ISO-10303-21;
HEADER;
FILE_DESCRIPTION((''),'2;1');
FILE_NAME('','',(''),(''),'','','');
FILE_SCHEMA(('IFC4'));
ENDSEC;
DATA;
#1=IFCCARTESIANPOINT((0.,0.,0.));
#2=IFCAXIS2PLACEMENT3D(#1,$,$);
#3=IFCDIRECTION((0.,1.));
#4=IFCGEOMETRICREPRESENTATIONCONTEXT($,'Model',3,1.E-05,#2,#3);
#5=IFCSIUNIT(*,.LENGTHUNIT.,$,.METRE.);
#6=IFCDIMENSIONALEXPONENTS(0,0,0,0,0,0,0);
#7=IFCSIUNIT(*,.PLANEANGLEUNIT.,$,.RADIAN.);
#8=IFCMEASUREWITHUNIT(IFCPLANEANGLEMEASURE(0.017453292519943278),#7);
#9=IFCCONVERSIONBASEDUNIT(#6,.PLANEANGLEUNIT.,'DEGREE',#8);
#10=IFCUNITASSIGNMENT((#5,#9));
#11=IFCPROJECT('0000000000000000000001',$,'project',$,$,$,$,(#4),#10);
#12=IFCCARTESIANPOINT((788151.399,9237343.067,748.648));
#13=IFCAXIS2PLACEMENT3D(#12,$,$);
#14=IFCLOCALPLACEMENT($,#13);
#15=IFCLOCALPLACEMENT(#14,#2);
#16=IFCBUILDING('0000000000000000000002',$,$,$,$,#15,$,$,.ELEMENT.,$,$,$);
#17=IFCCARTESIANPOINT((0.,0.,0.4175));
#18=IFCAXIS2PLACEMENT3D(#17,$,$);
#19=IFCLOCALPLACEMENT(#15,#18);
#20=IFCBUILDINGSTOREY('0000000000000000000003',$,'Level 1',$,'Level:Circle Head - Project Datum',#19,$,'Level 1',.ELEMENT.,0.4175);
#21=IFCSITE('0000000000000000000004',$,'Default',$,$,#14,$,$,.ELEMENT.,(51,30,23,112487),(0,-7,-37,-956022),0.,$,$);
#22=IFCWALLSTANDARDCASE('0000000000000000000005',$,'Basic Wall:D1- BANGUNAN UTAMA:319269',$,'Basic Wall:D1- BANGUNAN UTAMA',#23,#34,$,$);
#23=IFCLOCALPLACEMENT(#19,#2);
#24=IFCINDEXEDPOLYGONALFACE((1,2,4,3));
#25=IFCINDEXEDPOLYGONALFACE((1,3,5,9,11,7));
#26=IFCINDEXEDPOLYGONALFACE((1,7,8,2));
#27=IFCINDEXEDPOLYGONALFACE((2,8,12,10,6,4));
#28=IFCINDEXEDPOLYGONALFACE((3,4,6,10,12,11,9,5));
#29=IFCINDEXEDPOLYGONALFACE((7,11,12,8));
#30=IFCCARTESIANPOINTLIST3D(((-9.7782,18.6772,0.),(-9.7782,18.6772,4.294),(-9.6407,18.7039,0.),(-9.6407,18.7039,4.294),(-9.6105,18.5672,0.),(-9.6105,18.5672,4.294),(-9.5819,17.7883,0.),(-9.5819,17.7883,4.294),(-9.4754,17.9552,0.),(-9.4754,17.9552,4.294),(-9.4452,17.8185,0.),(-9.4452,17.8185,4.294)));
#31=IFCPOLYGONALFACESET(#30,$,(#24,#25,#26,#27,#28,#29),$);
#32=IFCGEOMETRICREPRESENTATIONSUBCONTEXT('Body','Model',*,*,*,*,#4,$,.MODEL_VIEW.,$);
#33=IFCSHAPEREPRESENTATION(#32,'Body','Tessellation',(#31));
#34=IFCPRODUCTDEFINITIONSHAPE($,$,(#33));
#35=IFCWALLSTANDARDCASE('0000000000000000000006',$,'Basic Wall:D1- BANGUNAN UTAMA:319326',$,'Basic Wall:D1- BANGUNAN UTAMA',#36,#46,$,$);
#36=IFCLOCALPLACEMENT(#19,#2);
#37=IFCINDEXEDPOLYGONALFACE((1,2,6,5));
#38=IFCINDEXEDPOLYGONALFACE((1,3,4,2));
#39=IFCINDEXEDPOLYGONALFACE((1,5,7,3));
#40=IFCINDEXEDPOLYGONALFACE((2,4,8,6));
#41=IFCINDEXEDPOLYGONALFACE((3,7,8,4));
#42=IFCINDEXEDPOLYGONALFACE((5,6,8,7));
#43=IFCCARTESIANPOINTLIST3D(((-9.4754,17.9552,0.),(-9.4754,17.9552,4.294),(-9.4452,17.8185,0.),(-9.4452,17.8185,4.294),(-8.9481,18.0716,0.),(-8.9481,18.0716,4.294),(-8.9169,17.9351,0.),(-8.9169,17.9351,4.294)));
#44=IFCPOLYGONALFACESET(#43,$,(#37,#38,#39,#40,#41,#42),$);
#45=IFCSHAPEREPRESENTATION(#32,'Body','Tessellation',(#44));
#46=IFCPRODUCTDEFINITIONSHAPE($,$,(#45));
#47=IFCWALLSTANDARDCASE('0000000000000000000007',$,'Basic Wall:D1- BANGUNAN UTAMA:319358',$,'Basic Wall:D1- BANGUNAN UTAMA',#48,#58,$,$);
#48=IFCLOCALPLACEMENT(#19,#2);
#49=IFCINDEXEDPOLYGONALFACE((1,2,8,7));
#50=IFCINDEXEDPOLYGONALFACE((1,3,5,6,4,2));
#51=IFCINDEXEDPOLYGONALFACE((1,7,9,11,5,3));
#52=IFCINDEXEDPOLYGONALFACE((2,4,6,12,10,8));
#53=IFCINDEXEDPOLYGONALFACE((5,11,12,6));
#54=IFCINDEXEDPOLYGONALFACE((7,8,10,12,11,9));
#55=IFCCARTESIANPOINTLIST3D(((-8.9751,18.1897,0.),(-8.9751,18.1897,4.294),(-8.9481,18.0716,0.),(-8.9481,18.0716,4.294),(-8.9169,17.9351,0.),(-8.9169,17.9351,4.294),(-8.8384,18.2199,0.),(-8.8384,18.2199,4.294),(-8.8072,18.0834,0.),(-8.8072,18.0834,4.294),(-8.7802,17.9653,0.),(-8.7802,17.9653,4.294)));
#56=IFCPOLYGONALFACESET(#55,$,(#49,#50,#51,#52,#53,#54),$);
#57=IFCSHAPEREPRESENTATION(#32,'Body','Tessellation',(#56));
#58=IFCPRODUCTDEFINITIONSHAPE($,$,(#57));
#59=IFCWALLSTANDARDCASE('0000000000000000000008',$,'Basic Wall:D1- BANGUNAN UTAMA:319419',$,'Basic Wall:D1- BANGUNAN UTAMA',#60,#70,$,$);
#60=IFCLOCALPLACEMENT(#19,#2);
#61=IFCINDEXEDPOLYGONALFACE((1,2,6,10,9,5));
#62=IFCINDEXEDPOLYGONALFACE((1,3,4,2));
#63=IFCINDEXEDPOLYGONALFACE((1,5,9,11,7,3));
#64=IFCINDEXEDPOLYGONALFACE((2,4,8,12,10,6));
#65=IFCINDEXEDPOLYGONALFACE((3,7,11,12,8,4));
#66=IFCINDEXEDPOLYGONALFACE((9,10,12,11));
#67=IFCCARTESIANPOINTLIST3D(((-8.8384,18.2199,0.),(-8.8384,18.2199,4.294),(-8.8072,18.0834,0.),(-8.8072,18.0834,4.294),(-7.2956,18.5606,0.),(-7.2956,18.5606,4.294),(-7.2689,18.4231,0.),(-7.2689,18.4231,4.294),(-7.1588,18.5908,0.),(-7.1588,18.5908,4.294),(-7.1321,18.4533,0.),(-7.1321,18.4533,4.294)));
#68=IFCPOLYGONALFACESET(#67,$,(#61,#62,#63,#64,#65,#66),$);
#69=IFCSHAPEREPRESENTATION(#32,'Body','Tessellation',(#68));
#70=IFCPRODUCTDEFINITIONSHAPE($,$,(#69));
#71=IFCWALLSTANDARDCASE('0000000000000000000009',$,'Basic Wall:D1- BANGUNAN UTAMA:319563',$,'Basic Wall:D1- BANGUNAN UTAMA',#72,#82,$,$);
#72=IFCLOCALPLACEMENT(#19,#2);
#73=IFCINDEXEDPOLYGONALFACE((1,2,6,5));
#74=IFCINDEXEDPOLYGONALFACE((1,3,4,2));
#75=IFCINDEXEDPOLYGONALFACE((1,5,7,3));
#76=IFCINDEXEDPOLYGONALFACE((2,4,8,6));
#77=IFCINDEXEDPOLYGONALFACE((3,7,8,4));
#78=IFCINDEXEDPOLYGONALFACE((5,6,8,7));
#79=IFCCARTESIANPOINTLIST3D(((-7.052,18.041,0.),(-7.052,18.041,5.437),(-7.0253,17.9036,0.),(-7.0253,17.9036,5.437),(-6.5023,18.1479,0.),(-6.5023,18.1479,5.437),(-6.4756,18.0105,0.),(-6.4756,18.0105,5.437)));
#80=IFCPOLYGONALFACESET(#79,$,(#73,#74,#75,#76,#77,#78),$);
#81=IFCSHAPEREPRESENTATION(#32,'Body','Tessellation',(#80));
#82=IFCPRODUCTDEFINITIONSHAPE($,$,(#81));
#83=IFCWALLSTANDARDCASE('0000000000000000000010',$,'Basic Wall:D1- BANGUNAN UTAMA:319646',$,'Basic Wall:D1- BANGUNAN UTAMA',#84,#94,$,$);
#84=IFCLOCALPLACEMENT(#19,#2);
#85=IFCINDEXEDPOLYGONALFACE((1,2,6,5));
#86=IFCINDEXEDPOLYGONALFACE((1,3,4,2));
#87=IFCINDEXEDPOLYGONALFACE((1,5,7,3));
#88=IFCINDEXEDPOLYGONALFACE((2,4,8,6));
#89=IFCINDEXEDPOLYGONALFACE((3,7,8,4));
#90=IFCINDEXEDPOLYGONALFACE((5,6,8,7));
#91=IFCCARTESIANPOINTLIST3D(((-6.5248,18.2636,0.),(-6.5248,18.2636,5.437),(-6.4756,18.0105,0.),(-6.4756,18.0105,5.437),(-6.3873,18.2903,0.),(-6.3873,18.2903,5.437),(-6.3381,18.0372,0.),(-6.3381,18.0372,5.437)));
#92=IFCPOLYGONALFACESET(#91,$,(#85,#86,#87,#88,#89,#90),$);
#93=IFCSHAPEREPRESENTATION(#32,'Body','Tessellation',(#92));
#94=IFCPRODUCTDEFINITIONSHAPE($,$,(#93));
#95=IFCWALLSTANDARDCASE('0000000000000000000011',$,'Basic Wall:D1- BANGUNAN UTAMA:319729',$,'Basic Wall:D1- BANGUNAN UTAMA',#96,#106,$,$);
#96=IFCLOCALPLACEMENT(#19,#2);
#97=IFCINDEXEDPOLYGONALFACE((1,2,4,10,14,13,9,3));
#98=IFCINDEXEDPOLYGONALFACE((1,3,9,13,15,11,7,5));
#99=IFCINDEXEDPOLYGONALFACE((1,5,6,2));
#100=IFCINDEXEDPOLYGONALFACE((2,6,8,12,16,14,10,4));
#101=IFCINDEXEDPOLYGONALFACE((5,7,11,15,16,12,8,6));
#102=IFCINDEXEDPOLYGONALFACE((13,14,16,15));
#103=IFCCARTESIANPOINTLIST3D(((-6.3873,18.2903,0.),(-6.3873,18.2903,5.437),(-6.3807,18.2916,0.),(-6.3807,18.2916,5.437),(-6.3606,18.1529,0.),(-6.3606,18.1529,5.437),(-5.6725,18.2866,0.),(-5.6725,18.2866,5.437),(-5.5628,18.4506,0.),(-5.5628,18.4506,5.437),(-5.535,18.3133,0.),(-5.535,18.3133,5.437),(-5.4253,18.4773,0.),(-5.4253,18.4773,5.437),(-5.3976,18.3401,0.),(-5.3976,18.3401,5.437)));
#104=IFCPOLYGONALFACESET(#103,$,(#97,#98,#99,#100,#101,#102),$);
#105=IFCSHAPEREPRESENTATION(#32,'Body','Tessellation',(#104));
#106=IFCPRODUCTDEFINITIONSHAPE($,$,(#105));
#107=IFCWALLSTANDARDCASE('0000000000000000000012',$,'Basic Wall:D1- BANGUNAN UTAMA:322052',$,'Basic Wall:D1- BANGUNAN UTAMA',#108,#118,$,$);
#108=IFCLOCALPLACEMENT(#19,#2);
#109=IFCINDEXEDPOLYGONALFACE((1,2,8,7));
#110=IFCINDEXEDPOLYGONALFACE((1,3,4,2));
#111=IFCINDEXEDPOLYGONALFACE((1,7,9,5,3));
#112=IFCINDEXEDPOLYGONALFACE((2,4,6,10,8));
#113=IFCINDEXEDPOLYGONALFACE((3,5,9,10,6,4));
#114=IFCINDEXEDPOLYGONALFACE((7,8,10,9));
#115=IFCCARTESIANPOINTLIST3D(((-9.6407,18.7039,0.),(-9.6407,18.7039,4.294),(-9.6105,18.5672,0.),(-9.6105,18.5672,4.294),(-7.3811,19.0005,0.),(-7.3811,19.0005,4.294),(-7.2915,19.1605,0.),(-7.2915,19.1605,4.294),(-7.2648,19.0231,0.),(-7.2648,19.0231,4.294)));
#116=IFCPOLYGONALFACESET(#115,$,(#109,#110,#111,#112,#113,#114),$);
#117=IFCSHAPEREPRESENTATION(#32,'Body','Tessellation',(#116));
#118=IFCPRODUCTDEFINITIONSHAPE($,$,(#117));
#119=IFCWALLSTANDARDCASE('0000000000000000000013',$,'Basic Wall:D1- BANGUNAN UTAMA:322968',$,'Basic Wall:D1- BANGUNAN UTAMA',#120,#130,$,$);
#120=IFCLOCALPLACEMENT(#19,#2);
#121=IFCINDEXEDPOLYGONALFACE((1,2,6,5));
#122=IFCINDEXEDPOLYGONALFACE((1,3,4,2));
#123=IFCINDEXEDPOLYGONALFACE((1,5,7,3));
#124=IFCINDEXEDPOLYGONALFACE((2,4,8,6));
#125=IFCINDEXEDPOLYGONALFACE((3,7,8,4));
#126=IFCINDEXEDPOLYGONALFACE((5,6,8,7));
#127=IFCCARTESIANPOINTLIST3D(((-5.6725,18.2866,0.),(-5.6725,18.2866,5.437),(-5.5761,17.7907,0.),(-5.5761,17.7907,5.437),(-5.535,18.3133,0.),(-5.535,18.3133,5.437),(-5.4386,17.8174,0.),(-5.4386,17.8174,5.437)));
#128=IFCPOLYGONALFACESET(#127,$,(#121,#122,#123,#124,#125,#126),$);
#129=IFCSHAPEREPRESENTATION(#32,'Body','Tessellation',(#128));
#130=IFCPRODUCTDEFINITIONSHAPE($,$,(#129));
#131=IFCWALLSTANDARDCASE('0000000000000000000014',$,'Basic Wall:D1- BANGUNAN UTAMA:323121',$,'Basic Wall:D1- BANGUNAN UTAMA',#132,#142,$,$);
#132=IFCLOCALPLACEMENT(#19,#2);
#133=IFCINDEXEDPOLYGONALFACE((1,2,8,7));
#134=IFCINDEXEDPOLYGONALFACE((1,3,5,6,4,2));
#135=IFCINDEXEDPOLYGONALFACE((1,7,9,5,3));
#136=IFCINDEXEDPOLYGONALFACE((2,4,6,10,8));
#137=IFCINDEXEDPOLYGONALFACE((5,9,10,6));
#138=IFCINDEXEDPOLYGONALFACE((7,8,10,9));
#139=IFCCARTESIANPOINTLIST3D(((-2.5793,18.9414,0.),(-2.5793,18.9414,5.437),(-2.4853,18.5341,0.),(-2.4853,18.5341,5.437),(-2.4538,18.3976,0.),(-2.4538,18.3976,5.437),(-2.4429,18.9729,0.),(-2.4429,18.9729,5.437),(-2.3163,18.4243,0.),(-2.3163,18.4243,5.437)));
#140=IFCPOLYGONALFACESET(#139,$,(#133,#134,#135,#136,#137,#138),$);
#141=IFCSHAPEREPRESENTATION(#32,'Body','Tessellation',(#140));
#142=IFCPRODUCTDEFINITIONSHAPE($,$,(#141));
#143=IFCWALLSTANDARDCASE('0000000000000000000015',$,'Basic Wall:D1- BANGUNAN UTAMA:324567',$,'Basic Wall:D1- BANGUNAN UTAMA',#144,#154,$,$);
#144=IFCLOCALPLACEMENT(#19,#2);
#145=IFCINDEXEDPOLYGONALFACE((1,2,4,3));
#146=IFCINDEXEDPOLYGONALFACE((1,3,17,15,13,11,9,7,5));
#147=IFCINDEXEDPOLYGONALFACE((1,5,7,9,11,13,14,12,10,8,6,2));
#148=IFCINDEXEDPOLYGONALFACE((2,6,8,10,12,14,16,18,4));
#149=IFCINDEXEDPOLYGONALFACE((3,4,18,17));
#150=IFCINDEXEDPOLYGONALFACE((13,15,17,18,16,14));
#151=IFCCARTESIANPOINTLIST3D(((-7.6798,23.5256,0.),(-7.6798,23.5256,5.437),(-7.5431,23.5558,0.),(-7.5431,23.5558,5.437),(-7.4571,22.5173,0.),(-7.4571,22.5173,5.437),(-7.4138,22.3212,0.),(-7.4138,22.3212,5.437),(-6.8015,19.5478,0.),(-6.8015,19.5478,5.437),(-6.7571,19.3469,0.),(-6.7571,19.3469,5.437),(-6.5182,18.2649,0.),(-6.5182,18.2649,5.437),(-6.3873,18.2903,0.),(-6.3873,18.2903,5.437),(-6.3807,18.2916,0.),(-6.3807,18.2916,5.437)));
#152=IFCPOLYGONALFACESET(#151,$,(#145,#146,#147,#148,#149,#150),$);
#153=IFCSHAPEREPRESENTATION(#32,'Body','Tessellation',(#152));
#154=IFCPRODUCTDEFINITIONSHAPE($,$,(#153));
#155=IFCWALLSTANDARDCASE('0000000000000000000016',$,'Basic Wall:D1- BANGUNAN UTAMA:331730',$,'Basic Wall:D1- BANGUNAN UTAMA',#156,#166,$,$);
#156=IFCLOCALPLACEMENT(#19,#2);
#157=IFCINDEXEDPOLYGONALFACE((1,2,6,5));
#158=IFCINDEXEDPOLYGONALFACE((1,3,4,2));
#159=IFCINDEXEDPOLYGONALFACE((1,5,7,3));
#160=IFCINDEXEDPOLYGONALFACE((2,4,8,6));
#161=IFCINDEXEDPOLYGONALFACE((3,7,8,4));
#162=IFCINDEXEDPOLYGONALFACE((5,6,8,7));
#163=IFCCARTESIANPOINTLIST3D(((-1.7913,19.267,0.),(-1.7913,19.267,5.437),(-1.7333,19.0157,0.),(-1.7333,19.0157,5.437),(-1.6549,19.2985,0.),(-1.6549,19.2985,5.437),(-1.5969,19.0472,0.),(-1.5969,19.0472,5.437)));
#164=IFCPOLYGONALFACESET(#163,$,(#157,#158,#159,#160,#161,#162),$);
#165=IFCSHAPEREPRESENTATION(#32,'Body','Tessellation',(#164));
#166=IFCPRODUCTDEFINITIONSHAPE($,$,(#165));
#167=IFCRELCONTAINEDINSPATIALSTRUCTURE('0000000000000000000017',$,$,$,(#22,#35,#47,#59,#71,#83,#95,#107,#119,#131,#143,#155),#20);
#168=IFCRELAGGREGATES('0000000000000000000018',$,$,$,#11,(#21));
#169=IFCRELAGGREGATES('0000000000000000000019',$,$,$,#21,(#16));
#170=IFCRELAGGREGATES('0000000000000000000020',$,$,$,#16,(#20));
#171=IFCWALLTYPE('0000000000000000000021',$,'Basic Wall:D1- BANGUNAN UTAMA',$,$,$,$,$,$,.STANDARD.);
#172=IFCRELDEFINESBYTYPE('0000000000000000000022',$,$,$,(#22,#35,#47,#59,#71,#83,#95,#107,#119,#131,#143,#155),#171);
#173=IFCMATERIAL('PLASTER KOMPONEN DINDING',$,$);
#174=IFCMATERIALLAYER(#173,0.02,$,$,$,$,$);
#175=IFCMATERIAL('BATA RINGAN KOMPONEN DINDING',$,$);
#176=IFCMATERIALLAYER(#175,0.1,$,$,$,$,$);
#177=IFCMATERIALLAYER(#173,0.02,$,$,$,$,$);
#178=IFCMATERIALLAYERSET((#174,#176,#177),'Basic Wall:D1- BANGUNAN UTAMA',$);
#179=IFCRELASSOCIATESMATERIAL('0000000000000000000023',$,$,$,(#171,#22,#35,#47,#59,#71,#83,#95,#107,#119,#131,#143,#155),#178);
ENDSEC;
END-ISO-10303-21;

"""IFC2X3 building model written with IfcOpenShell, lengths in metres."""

from ifc_helpers import new_model, entity, si_unit, converted_unit, direction, frame, frame_2d, origin, place, context, subcontext, project, spatial, polyline, rectangle, outline, extrude, material, layer, layer_set, layer_usage, type_object, element, save


model = new_model("IFC2X3")

# Units and contexts
model_context = context("Model", 3, precision=1e-05, world=origin(), true_north=direction((0.0, 1.0)))
body_context = subcontext(model_context, "Body", "Model", "MODEL_VIEW")
ifc_project = project(units=[si_unit("LENGTHUNIT", "METRE"), converted_unit("PLANEANGLEUNIT", "DEGREE", entity("IfcPlaneAngleMeasure", 0.017453292519943278), si_unit("PLANEANGLEUNIT", "RADIAN"), dimensions=[0, 0, 0, 0, 0, 0, 0])], contexts=[model_context])

# Site, building, storey
site_placement = place(None, frame((788151.399, 9237343.067, 748.648)))
site = spatial("IfcSite", under=ifc_project, at=site_placement, Name="Default", CompositionType="ELEMENT", RefLatitude=(51, 30, 23, 112487), RefLongitude=(0, -7, -37, -956022), RefElevation=0.0)
building_placement = place(site_placement, origin())
building = spatial("IfcBuilding", under=site, at=building_placement, CompositionType="ELEMENT")
storey_placement = place(building_placement, frame((0.0, 0.0, 0.4175)))
storey = spatial("IfcBuildingStorey", under=building, at=storey_placement, Name="Level 1", ObjectType="Level:Circle Head - Project Datum", LongName="Level 1", CompositionType="ELEMENT", Elevation=0.4175)

# Walls
ifc_material_1 = material(Name="PLASTER KOMPONEN DINDING")
ifc_layer_1 = layer(ifc_material_1, 0.02)
ifc_material_2 = material(Name="BATA RINGAN KOMPONEN DINDING")
ifc_layer_2 = layer(ifc_material_2, 0.1)
ifc_layer_3 = layer(ifc_material_1, 0.02)
ifc_layer_set_1 = layer_set([ifc_layer_1, ifc_layer_2, ifc_layer_3], Name="Basic Wall:D1- BANGUNAN UTAMA")
ifc_layer_usage_1 = layer_usage(ifc_layer_set_1, "AXIS2", "NEGATIVE", 0.07)
wall_type = type_object("IfcWallType", Name="Basic Wall:D1- BANGUNAN UTAMA", PredefinedType="STANDARD", material=ifc_layer_set_1)
wall_1_placement = place(storey_placement, frame((-9.7098, 18.6923, 0.0), z_axis=(0.0, 0.0, 1.0), x_axis=(0.215604, -0.976481, 0.0)))
element("IfcWallStandardCase", 1, at=wall_1_placement, inside=storey, type_object=wall_type, material=ifc_layer_usage_1, Name="Basic Wall:D1- BANGUNAN UTAMA:319269", ObjectType="Basic Wall:D1- BANGUNAN UTAMA", context=body_context, shape_type="SweptSolid", body=[
    extrude(outline(polyline([(0.9103, -0.07), (0.9103, 0.07), (0.7703, 0.07), (0.1436, 0.07), (0.0035, 0.07), (0.0, -0.07), (0.9103, -0.07)])), origin(), (0.0, 0.0, 1.0), 4.294),
])
ifc_layer_usage_2 = layer_usage(ifc_layer_set_1, "AXIS2", "NEGATIVE", 0.07)
wall_2_placement = place(storey_placement, frame((-9.4603, 17.8868, 0.0), z_axis=(0.0, 0.0, 1.0), x_axis=(0.976481, 0.215604, 0.0)))
element("IfcWallStandardCase", 2, at=wall_2_placement, inside=storey, type_object=wall_type, material=ifc_layer_usage_2, Name="Basic Wall:D1- BANGUNAN UTAMA:319326", ObjectType="Basic Wall:D1- BANGUNAN UTAMA", context=body_context, shape_type="SweptSolid", body=[
    extrude(outline(polyline([(0.541, -0.07), (0.54, 0.07), (0.0, 0.07), (0.0, -0.07), (0.541, -0.07)])), origin(), (0.0, 0.0, 1.0), 4.294),
])
ifc_layer_usage_3 = layer_usage(ifc_layer_set_1, "AXIS2", "NEGATIVE", 0.07)
wall_3_placement = place(storey_placement, frame((-8.8484, 17.9497, 0.0), z_axis=(0.0, 0.0, 1.0), x_axis=(-0.222913, 0.974838, 0.0)))
element("IfcWallStandardCase", 3, at=wall_3_placement, inside=storey, type_object=wall_type, material=ifc_layer_usage_3, Name="Basic Wall:D1- BANGUNAN UTAMA:319358", ObjectType="Basic Wall:D1- BANGUNAN UTAMA", context=body_context, shape_type="SweptSolid", body=[
    extrude(outline(polyline([(0.2612, -0.07), (0.2622, 0.07), (0.1411, 0.07), (0.001, 0.07), (0.0, -0.07), (0.1212, -0.07), (0.2612, -0.07)])), origin(), (0.0, 0.0, 1.0), 4.294),
])
ifc_layer_usage_4 = layer_usage(ifc_layer_set_1, "AXIS2", "NEGATIVE", 0.07)
wall_4_placement = place(storey_placement, frame((-8.8233, 18.1516, 0.0), z_axis=(0.0, 0.0, 1.0), x_axis=(0.976481, 0.215604, 0.0)))
element("IfcWallStandardCase", 4, at=wall_4_placement, inside=storey, type_object=wall_type, material=ifc_layer_usage_4, Name="Basic Wall:D1- BANGUNAN UTAMA:319419", ObjectType="Basic Wall:D1- BANGUNAN UTAMA", context=body_context, shape_type="SweptSolid", body=[
    extrude(outline(polyline([(1.7164, -0.07), (1.72, 0.07), (1.58, 0.07), (0.0, 0.07), (0.001, -0.07), (1.5764, -0.07), (1.7164, -0.07)])), origin(), (0.0, 0.0, 1.0), 4.294),
])
ifc_layer_usage_5 = layer_usage(ifc_layer_set_1, "AXIS2", "NEGATIVE", 0.07)
wall_5_placement = place(storey_placement, frame((-7.0386, 17.9723, 0.0), z_axis=(0.0, 0.0, 1.0), x_axis=(0.981627, 0.190809, 0.0)))
element("IfcWallStandardCase", 5, at=wall_5_placement, inside=storey, type_object=wall_type, material=ifc_layer_usage_5, Name="Basic Wall:D1- BANGUNAN UTAMA:319563", ObjectType="Basic Wall:D1- BANGUNAN UTAMA", context=body_context, shape_type="SweptSolid", body=[
    extrude(rectangle(XDim=0.56, YDim=0.14, at=frame_2d((0.28, 0.0), x_axis=(-1.0, 0.0))), origin(), (0.0, 0.0, 1.0), 5.437),
])
ifc_layer_usage_6 = layer_usage(ifc_layer_set_1, "AXIS2", "NEGATIVE", 0.07)
wall_6_placement = place(storey_placement, frame((-6.4068, 18.0238, 0.0), z_axis=(0.0, 0.0, 1.0), x_axis=(-0.190809, 0.981627, 0.0)))
element("IfcWallStandardCase", 6, at=wall_6_placement, inside=storey, type_object=wall_type, material=ifc_layer_usage_6, Name="Basic Wall:D1- BANGUNAN UTAMA:319646", ObjectType="Basic Wall:D1- BANGUNAN UTAMA", context=body_context, shape_type="SweptSolid", body=[
    extrude(rectangle(XDim=0.2578, YDim=0.14, at=frame_2d((0.1289, 0.0), x_axis=(-1.0, 0.0))), origin(), (0.0, 0.0, 1.0), 5.437),
])
ifc_layer_usage_7 = layer_usage(ifc_layer_set_1, "AXIS2", "NEGATIVE", 0.07)
wall_7_placement = place(storey_placement, frame((-6.374, 18.2216, 0.0), z_axis=(0.0, 0.0, 1.0), x_axis=(0.981627, 0.190809, 0.0)))
element("IfcWallStandardCase", 7, at=wall_7_placement, inside=storey, type_object=wall_type, material=ifc_layer_usage_7, Name="Basic Wall:D1- BANGUNAN UTAMA:319729", ObjectType="Basic Wall:D1- BANGUNAN UTAMA", context=body_context, shape_type="SweptSolid", body=[
    extrude(outline(polyline([(0.981, -0.07), (0.98, 0.07), (0.84, 0.07), (0.0067, 0.07), (0.0, 0.07), (0.0, -0.07), (0.701, -0.07), (0.841, -0.07), (0.981, -0.07)])), origin(), (0.0, 0.0, 1.0), 5.437),
])
ifc_layer_usage_8 = layer_usage(ifc_layer_set_1, "AXIS2", "NEGATIVE", 0.07)
wall_8_placement = place(storey_placement, frame((-7.2781, 19.0918, 0.0), z_axis=(0.0, 0.0, 1.0), x_axis=(-0.981627, -0.190809, 0.0)))
element("IfcWallStandardCase", 8, at=wall_8_placement, inside=storey, type_object=wall_type, material=ifc_layer_usage_8, Name="Basic Wall:D1- BANGUNAN UTAMA:322052", ObjectType="Basic Wall:D1- BANGUNAN UTAMA", context=body_context, shape_type="SweptSolid", body=[
    extrude(outline(polyline([(2.3932, -0.07), (2.3896, 0.07), (0.1185, 0.07), (0.0, 0.07), (0.0, -0.07), (2.3932, -0.07)])), origin(), (0.0, 0.0, 1.0), 4.294),
])
ifc_layer_usage_9 = layer_usage(ifc_layer_set_1, "AXIS2", "NEGATIVE", 0.07)
wall_9_placement = place(storey_placement, frame((-5.6038, 18.3, 0.0), z_axis=(0.0, 0.0, 1.0), x_axis=(0.190809, -0.981627, 0.0)))
element("IfcWallStandardCase", 9, at=wall_9_placement, inside=storey, type_object=wall_type, material=ifc_layer_usage_9, Name="Basic Wall:D1- BANGUNAN UTAMA:322968", ObjectType="Basic Wall:D1- BANGUNAN UTAMA", context=body_context, shape_type="SweptSolid", body=[
    extrude(rectangle(XDim=0.5053, YDim=0.14, at=frame_2d((0.2526, 0.0), x_axis=(-1.0, 0.0))), origin(), (0.0, 0.0, 1.0), 5.437),
])
ifc_layer_usage_10 = layer_usage(ifc_layer_set_1, "AXIS2", "POSITIVE", -0.07)
wall_10_placement = place(storey_placement, frame((-2.5111, 18.9572, 0.0), z_axis=(0.0, 0.0, 1.0), x_axis=(0.224853, -0.974393, 0.0)))
element("IfcWallStandardCase", 10, at=wall_10_placement, inside=storey, type_object=wall_type, material=ifc_layer_usage_10, Name="Basic Wall:D1- BANGUNAN UTAMA:323121", ObjectType="Basic Wall:D1- BANGUNAN UTAMA", context=body_context, shape_type="SweptSolid", body=[
    extrude(outline(polyline([(0.5582, -0.07), (0.563, 0.07), (0.0, 0.07), (0.0, -0.07), (0.4181, -0.07), (0.5582, -0.07)])), origin(), (0.0, 0.0, 1.0), 5.437),
])
ifc_layer_usage_11 = layer_usage(ifc_layer_set_1, "AXIS2", "POSITIVE", -0.07)
wall_11_placement = place(storey_placement, frame((-6.4491, 18.2765, 0.0), z_axis=(0.0, 0.0, 1.0), x_axis=(-0.215604, 0.976481, 0.0)))
element("IfcWallStandardCase", 11, at=wall_11_placement, inside=storey, type_object=wall_type, material=ifc_layer_usage_11, Name="Basic Wall:D1- BANGUNAN UTAMA:324567", ObjectType="Basic Wall:D1- BANGUNAN UTAMA", context=body_context, shape_type="SweptSolid", body=[
    extrude(outline(polyline([(5.391, -0.07), (5.391, 0.07), (4.3584, 0.07), (4.1576, 0.07), (1.3174, 0.07), (1.1116, 0.07), (0.0035, 0.07), (0.0002, -0.0633), (0.0, -0.07), (5.391, -0.07)])), origin(), (0.0, 0.0, 1.0), 5.437),
])
ifc_layer_usage_12 = layer_usage(ifc_layer_set_1, "AXIS2", "POSITIVE", -0.07)
wall_12_placement = place(storey_placement, frame((-1.6651, 19.0315, 0.0), z_axis=(0.0, 0.0, 1.0), x_axis=(-0.224853, 0.974393, 0.0)))
element("IfcWallStandardCase", 12, at=wall_12_placement, inside=storey, type_object=wall_type, material=ifc_layer_usage_12, Name="Basic Wall:D1- BANGUNAN UTAMA:331730", ObjectType="Basic Wall:D1- BANGUNAN UTAMA", context=body_context, shape_type="SweptSolid", body=[
    extrude(rectangle(XDim=0.2578, YDim=0.14, at=frame_2d((0.1289, 0.0), x_axis=(-1.0, 0.0))), origin(), (0.0, 0.0, 1.0), 5.437),
])

save(model, "model.ifc")
